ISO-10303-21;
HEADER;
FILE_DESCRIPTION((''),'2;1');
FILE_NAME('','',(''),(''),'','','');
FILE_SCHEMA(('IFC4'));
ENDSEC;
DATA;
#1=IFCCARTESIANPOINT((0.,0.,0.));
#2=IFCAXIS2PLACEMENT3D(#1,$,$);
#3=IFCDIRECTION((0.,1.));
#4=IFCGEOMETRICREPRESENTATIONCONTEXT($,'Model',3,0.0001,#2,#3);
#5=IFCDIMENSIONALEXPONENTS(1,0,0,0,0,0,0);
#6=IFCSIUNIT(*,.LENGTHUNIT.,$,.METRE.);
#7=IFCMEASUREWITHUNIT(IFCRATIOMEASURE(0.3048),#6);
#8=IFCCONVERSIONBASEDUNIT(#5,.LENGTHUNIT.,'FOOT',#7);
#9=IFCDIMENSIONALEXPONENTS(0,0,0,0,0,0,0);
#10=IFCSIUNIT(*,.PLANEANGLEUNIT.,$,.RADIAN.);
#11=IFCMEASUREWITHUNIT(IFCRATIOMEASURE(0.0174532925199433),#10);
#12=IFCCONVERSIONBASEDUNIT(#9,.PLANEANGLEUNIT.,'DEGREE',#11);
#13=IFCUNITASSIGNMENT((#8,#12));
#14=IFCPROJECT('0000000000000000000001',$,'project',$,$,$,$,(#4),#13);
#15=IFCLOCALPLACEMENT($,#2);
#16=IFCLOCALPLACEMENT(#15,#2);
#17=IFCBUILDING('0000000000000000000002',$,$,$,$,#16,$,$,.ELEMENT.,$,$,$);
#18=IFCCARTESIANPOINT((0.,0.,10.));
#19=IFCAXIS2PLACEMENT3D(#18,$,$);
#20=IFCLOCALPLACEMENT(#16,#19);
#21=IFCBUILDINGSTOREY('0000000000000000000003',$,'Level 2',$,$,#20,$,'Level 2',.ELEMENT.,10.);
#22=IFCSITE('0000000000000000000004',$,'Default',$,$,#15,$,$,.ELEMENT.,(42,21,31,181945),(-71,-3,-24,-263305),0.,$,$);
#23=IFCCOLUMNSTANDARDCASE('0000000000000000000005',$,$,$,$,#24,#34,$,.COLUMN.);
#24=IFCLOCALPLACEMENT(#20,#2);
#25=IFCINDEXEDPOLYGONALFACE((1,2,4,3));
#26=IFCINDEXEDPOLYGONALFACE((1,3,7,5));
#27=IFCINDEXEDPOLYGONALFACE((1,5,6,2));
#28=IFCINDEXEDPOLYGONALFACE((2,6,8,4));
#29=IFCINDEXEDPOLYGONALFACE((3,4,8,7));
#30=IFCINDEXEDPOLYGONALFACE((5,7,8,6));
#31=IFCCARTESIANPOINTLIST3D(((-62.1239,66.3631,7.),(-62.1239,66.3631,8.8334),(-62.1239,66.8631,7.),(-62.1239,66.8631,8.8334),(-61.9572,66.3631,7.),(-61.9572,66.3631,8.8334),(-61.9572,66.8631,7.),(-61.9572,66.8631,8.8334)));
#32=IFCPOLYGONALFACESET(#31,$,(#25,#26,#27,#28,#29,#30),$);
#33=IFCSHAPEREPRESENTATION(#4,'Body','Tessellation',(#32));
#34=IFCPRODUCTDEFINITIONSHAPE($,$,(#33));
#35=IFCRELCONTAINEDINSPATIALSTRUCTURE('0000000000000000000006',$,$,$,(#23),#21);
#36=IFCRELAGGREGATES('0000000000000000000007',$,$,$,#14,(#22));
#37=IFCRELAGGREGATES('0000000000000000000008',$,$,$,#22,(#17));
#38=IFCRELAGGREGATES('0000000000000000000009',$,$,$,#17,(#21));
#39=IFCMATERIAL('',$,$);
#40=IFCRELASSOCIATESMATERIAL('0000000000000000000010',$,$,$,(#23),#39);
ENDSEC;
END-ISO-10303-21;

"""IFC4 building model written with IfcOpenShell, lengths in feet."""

from ifc_helpers import new_model, entity, si_unit, converted_unit, direction, frame, origin, place, context, project, spatial, rectangle, extrude, material, element, save


model = new_model("IFC4")

# Units and contexts
model_context = context("Model", 3, precision=0.0001, world=origin(), true_north=direction((0.0, 1.0)))
ifc_project = project(units=[converted_unit("LENGTHUNIT", "FOOT", entity("IfcRatioMeasure", 0.3048), si_unit("LENGTHUNIT", "METRE"), dimensions=[1, 0, 0, 0, 0, 0, 0]), converted_unit("PLANEANGLEUNIT", "DEGREE", entity("IfcRatioMeasure", 0.0174532925199433), si_unit("PLANEANGLEUNIT", "RADIAN"), dimensions=[0, 0, 0, 0, 0, 0, 0])], contexts=[model_context])

# Site, building, storey
site_placement = place(None, origin())
site = spatial("IfcSite", under=ifc_project, at=site_placement, Name="Default", CompositionType="ELEMENT", RefLatitude=(42, 21, 31, 181945), RefLongitude=(-71, -3, -24, -263305), RefElevation=0.0)
building_placement = place(site_placement, origin())
building = spatial("IfcBuilding", under=site, at=building_placement, CompositionType="ELEMENT")
storey_placement = place(building_placement, frame((0.0, 0.0, 10.0)))
storey = spatial("IfcBuildingStorey", under=building, at=storey_placement, Name="Level 2", LongName="Level 2", CompositionType="ELEMENT", Elevation=10.0)

# Column
placement_1 = place(storey_placement, frame((-69.9573, 66.6131, 0.0)))
ifc_material_1 = material(Name="")
for number, where, z_axis, x_axis in (
    (1, (7.9167, 0.0, 7.0), (0.0, 0.0, 1.0), (1.0, 0.0, 0.0)),
):
    element("IfcColumnStandardCase", number, at=place(placement_1, frame(where, z_axis=z_axis, x_axis=x_axis)), inside=storey, material=ifc_material_1, PredefinedType="COLUMN", context=model_context, shape_type="SweptSolid", body=[
        extrude(rectangle(XDim=0.1667, YDim=0.5), origin(), (0.0, 0.0, 1.0), 1.8334),
    ])

save(model, "model.ifc")
